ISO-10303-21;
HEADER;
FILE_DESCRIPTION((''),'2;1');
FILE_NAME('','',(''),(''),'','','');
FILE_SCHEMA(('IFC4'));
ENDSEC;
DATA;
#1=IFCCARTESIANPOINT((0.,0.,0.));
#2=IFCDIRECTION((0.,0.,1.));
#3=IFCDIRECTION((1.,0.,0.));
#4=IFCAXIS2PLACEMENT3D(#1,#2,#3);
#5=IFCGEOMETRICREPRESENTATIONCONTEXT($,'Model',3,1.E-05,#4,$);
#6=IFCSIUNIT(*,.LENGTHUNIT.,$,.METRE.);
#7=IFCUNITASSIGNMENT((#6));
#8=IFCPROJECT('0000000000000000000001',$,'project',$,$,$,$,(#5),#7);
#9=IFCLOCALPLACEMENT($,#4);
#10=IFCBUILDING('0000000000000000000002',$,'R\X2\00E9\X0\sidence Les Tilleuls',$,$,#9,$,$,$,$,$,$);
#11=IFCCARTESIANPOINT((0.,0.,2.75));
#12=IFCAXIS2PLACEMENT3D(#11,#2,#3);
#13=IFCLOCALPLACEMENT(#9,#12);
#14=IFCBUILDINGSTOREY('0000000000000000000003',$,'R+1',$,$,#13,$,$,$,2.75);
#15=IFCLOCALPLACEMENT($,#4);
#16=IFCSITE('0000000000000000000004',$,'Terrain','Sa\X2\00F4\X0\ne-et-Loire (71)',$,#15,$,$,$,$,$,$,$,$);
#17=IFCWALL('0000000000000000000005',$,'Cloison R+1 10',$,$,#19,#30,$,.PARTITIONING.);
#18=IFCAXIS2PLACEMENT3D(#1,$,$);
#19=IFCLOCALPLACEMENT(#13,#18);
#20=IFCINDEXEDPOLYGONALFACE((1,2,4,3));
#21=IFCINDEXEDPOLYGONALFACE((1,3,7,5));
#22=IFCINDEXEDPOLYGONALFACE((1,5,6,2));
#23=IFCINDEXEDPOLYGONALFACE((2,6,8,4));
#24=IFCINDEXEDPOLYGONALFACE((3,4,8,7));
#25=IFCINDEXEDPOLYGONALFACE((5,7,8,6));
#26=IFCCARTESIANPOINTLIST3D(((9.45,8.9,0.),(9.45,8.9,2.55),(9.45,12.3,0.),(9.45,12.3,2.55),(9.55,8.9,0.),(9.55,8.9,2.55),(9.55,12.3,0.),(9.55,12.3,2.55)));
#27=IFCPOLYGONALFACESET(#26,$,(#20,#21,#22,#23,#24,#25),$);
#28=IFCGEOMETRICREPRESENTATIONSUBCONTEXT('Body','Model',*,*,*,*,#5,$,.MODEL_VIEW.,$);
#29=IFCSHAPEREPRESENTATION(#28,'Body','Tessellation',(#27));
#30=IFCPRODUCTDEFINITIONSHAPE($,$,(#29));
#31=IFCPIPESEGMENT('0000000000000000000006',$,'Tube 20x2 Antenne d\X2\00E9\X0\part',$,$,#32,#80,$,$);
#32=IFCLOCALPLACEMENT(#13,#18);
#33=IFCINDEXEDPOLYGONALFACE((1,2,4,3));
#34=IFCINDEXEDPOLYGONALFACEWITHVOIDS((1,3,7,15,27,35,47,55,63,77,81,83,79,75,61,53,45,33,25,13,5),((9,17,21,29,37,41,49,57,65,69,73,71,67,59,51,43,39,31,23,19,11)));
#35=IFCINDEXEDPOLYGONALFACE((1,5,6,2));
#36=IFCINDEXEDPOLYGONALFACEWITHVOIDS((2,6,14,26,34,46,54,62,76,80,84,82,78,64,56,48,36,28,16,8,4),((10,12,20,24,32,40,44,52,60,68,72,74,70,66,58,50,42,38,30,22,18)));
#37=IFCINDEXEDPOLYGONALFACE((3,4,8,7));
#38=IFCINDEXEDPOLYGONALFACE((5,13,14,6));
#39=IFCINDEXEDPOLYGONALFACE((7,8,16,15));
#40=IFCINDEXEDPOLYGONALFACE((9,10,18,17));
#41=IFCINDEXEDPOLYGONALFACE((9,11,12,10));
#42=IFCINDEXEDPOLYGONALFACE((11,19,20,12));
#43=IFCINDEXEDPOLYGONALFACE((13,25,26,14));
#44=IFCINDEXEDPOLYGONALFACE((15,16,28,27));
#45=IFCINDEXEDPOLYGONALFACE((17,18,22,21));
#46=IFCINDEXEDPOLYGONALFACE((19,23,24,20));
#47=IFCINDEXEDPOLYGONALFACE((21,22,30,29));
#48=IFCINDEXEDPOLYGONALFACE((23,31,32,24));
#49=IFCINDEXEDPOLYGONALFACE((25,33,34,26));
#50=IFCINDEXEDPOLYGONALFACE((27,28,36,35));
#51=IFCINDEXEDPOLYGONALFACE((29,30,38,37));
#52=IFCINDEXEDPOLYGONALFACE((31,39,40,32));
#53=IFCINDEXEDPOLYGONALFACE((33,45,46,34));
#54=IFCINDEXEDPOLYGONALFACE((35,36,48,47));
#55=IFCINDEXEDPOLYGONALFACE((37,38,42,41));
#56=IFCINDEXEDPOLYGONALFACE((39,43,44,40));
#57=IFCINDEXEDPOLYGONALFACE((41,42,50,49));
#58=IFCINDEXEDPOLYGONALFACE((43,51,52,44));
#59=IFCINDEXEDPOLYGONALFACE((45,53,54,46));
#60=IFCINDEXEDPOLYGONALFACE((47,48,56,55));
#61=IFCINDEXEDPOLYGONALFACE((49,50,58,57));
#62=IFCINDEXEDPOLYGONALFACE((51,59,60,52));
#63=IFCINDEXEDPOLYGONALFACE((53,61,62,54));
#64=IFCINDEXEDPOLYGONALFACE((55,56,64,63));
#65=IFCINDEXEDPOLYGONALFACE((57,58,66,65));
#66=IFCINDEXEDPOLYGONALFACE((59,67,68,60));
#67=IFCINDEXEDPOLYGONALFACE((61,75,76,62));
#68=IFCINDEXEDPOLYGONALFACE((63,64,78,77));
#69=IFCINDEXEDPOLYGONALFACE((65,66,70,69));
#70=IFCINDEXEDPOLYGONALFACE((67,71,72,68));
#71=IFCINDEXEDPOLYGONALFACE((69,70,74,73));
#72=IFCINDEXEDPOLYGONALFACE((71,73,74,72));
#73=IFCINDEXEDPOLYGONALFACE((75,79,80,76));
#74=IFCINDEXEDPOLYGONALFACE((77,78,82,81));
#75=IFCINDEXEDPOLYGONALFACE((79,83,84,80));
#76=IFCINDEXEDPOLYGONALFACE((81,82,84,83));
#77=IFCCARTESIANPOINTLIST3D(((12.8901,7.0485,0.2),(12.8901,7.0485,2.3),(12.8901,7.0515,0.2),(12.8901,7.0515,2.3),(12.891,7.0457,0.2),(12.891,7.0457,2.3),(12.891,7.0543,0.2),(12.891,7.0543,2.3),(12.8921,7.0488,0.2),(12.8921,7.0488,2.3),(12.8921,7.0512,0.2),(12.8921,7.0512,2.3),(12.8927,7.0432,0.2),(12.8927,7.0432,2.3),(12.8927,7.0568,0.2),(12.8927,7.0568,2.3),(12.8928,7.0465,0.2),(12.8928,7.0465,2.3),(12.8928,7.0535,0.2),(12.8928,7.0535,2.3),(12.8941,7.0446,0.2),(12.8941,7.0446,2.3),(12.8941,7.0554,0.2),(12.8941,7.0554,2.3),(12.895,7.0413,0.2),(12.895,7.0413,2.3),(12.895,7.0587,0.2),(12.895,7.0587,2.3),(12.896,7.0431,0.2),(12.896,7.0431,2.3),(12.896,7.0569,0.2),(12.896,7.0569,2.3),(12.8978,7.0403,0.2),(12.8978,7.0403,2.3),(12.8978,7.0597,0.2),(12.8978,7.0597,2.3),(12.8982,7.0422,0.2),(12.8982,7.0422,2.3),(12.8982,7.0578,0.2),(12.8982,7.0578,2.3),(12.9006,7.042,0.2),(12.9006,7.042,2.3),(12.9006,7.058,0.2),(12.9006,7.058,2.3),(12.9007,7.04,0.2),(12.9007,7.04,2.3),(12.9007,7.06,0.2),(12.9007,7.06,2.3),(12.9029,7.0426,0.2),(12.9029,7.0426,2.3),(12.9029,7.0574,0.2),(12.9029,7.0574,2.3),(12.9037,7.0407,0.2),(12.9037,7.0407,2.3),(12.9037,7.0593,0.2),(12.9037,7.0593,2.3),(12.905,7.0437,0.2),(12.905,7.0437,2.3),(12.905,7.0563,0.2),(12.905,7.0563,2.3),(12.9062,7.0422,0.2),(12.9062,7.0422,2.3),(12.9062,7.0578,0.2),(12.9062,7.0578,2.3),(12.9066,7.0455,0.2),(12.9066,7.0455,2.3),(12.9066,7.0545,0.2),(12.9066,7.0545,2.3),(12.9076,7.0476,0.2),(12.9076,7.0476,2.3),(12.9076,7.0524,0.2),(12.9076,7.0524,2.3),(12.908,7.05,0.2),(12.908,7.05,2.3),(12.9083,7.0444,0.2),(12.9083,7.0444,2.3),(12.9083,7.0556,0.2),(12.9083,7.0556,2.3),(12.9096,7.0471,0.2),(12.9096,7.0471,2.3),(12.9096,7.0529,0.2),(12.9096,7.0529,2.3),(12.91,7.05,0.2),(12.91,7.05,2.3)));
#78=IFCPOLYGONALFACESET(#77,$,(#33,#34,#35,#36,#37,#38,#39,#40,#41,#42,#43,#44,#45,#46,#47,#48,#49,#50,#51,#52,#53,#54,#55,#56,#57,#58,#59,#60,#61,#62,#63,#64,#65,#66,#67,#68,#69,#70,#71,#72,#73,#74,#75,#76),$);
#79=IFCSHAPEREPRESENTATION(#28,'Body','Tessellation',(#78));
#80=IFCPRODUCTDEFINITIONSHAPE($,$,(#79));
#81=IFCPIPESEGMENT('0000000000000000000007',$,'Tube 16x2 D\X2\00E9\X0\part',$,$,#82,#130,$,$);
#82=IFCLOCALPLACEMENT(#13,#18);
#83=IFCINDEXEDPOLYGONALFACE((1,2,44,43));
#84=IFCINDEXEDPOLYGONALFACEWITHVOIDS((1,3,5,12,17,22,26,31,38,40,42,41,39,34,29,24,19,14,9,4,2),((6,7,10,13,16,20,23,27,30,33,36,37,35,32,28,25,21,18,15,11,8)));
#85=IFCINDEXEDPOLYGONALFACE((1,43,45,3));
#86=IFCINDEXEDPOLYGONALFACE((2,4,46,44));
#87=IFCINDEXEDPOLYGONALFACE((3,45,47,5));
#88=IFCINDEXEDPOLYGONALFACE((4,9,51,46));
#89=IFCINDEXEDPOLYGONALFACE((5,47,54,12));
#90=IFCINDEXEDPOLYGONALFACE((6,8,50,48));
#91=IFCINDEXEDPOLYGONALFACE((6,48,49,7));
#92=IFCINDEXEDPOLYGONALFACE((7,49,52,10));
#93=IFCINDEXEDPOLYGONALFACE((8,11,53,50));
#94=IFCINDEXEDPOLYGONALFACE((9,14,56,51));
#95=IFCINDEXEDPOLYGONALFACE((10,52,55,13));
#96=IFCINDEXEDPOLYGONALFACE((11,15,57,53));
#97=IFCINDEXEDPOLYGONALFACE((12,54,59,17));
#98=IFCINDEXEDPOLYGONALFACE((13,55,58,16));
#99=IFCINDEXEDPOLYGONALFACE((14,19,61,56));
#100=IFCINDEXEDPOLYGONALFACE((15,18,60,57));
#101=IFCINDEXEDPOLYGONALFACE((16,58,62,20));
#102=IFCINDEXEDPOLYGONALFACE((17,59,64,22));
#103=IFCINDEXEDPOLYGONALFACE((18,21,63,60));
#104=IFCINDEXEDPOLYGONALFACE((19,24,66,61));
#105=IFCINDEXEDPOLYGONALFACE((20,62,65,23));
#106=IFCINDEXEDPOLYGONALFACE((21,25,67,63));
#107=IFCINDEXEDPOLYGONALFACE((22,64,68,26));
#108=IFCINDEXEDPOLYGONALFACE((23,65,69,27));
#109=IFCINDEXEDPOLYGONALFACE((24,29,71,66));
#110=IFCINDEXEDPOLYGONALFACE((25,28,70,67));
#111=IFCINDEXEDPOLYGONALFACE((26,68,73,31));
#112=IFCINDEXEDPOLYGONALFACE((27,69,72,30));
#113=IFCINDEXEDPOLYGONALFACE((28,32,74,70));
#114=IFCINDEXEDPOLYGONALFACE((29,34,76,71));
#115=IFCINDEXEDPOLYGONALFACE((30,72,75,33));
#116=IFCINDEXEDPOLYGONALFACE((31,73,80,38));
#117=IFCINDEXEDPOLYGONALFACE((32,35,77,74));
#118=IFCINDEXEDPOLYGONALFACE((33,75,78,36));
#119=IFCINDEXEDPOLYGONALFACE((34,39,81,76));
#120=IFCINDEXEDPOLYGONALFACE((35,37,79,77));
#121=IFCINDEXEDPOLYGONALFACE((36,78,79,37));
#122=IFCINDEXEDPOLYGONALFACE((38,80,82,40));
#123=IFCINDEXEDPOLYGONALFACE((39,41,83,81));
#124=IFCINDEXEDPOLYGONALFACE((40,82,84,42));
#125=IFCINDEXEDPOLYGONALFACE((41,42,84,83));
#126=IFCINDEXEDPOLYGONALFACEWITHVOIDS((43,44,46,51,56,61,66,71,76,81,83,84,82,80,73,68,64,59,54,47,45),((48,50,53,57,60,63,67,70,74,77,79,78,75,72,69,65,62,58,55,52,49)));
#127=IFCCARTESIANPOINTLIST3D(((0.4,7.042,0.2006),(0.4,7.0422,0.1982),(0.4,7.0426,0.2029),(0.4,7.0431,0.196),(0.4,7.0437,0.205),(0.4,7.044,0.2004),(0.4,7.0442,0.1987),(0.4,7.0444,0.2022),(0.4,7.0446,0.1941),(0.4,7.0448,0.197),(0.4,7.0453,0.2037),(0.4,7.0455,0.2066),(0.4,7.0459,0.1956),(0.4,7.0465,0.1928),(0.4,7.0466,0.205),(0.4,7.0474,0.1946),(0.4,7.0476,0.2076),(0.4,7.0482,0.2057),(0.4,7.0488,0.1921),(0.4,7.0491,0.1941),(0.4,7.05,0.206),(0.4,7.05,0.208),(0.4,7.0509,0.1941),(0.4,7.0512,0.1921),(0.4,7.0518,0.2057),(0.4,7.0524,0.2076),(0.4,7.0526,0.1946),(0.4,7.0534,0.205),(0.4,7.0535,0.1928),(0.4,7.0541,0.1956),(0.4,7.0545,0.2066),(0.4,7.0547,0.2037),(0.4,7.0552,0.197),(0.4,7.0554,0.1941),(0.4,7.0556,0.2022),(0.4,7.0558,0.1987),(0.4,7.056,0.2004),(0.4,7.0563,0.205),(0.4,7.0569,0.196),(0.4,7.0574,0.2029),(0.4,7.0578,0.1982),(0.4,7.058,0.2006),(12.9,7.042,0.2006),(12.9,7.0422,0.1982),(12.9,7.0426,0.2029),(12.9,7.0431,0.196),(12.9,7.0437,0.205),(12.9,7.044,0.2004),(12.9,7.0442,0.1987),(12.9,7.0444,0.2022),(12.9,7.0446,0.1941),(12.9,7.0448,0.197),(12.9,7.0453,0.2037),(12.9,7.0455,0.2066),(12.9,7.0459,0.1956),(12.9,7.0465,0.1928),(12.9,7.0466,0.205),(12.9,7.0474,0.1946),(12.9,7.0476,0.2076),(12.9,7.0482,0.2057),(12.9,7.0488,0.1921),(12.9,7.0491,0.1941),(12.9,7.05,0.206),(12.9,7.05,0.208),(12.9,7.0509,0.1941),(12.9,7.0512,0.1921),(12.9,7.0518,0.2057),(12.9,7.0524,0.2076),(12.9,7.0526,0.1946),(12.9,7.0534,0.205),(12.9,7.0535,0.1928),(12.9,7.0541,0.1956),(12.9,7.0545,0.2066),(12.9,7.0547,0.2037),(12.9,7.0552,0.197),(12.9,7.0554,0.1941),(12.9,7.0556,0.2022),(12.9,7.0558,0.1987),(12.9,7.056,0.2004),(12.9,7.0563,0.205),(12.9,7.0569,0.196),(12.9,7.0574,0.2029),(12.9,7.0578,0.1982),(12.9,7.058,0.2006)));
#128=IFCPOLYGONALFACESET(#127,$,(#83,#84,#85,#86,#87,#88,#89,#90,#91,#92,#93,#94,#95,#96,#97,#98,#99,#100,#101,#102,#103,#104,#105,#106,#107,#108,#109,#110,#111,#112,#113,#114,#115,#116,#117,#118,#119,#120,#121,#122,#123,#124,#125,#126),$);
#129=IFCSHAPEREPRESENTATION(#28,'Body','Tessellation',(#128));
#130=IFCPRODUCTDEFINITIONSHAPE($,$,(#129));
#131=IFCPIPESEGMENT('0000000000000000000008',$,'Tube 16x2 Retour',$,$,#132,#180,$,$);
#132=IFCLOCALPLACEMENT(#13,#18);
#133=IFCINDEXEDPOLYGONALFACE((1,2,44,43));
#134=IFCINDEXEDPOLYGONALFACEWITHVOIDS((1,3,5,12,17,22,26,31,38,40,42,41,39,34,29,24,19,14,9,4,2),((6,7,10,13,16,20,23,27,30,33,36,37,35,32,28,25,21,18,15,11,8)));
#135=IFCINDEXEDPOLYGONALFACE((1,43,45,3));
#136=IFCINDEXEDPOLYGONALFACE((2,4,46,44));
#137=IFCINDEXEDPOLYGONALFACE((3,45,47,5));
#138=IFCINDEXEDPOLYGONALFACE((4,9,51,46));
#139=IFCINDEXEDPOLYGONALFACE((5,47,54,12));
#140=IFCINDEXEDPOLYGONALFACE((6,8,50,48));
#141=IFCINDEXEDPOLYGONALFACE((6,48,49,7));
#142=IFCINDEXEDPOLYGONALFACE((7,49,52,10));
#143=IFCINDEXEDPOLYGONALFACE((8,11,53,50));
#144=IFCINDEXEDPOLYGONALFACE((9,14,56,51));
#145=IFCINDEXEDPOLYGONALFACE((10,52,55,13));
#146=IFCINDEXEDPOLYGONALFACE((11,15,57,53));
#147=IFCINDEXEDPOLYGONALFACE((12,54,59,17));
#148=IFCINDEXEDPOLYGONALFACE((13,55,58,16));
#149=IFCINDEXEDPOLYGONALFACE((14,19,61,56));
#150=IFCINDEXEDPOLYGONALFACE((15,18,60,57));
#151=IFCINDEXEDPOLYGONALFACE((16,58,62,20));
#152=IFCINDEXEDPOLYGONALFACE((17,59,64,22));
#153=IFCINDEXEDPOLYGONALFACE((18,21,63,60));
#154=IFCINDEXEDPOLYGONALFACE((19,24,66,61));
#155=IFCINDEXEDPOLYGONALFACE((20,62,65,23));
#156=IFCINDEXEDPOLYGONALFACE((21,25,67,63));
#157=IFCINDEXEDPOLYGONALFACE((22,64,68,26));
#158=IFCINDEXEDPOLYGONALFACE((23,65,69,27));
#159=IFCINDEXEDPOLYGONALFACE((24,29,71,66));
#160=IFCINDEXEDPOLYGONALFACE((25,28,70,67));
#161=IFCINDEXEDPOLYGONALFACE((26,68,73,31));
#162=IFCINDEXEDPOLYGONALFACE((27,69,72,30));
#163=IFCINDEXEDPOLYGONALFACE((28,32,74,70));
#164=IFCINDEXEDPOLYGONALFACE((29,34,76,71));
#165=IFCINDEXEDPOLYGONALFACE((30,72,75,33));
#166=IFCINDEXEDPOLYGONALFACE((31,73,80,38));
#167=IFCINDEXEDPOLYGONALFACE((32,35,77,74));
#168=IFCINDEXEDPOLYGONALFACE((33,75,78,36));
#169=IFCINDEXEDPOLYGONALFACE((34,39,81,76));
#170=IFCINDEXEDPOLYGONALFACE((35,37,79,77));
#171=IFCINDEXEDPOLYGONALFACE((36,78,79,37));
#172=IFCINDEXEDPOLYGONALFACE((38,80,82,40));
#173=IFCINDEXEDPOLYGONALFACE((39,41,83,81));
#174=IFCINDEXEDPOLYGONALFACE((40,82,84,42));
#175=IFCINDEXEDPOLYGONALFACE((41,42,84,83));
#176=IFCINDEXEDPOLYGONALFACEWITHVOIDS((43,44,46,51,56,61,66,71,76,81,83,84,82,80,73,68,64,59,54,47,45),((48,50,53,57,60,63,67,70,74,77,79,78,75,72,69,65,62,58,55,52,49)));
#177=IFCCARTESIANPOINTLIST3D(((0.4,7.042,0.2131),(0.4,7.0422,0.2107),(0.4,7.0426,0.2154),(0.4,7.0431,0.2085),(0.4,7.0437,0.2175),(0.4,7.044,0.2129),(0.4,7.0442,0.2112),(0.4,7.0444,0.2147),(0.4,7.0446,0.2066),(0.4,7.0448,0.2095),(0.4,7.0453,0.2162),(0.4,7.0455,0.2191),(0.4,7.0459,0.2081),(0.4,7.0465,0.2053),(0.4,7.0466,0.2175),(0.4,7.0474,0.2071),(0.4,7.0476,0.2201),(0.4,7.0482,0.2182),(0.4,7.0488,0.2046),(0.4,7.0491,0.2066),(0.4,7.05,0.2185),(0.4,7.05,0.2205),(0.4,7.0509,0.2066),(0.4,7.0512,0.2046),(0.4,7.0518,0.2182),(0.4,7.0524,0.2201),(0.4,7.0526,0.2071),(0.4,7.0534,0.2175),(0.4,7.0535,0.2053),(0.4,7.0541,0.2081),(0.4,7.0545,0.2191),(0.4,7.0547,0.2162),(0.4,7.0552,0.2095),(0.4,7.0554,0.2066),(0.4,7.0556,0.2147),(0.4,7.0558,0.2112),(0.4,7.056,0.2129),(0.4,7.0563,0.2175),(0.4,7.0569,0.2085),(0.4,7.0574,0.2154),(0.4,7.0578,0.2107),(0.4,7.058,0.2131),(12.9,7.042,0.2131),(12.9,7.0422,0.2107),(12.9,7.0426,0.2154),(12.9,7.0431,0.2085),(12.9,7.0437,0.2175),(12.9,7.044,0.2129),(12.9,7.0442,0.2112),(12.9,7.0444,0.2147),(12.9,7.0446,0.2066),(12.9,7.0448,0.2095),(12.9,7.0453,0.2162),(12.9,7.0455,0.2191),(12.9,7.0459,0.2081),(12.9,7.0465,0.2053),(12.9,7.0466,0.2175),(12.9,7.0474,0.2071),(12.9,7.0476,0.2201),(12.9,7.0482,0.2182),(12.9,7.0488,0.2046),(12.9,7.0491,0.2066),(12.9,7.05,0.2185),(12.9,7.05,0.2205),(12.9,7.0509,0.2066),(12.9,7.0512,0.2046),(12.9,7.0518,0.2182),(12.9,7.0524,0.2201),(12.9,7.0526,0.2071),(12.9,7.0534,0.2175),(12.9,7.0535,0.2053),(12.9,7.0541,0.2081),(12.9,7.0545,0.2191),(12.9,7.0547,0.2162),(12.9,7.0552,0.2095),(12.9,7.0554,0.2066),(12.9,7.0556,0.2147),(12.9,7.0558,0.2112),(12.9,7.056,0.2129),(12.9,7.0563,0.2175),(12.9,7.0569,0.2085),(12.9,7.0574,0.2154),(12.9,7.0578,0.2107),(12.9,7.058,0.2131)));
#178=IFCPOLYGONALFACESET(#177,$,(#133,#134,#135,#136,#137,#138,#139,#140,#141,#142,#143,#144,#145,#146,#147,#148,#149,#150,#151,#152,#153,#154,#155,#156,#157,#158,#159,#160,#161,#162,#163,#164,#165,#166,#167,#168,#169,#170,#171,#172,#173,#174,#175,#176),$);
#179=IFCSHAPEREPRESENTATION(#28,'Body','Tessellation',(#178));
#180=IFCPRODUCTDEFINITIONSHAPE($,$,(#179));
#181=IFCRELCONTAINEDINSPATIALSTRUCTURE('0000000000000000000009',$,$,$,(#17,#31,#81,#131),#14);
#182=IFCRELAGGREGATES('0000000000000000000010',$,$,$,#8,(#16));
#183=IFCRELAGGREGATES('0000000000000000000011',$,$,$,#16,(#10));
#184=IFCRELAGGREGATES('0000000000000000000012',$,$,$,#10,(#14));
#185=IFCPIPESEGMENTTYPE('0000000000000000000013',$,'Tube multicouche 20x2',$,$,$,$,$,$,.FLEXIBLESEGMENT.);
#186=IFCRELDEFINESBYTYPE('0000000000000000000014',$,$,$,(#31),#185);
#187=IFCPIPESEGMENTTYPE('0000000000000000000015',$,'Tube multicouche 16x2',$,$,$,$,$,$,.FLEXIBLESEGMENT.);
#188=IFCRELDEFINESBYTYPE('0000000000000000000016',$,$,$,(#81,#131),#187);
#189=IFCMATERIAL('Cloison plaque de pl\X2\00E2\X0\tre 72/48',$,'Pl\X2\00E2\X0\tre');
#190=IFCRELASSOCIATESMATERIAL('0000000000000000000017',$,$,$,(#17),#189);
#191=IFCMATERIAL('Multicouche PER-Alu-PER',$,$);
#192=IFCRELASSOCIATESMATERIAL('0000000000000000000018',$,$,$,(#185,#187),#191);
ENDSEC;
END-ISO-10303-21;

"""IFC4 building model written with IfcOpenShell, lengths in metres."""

from ifc_helpers import new_model, si_unit, frame, frame_2d, origin_with_axes, place, context, subcontext, project, spatial, rectangle, hollow_circle, extrude, material, type_object, element, save


model = new_model("IFC4")

# Units and contexts
model_context = context("Model", 3, precision=1e-05, world=origin_with_axes())
body_context = subcontext(model_context, "Body", "Model", "MODEL_VIEW")
ifc_project = project(units=[si_unit("LENGTHUNIT", "METRE")], contexts=[model_context])

# Site, building, storey
site_placement = place(None, origin_with_axes())
site = spatial("IfcSite", under=ifc_project, at=site_placement, Name="Terrain", Description="Saône-et-Loire (71)")
building_placement = place(None, origin_with_axes())
building = spatial("IfcBuilding", under=site, at=building_placement, Name="Résidence Les Tilleuls")
storey_placement = place(building_placement, frame((0.0, 0.0, 2.75), z_axis=(0.0, 0.0, 1.0), x_axis=(1.0, 0.0, 0.0)))
storey = spatial("IfcBuildingStorey", under=building, at=storey_placement, Name="R+1", Elevation=2.75)

# Wall
ifc_material_1 = material(Name="Cloison plaque de plâtre 72/48", Category="Plâtre")
wall_placement = place(storey_placement, frame((9.45, 8.9, 0.0), z_axis=(0.0, 0.0, 1.0), x_axis=(1.0, 0.0, 0.0)))
element("IfcWall", 1, at=wall_placement, inside=storey, material=ifc_material_1, Name="Cloison R+1 10", PredefinedType="PARTITIONING", context=body_context, shape_type="SweptSolid", body=[
    extrude(rectangle(XDim=0.1, YDim=3.4, at=frame_2d((0.05, 1.7))), origin_with_axes(), (0.0, 0.0, 1.0), 2.55),
])

# Pipe segments
ifc_material_2 = material(Name="Multicouche PER-Alu-PER")
pipe_segment_type_1 = type_object("IfcPipeSegmentType", Name="Tube multicouche 20x2", PredefinedType="FLEXIBLESEGMENT", material=ifc_material_2)
pipe_segment_1_placement = place(storey_placement, frame((12.9, 7.05, 2.3), z_axis=(0.0, 0.0, -1.0), x_axis=(1.0, 0.0, 0.0)))
element("IfcPipeSegment", 2, at=pipe_segment_1_placement, inside=storey, type_object=pipe_segment_type_1, Name="Tube 20x2 Antenne départ", context=body_context, shape_type="SweptSolid", body=[
    extrude(hollow_circle(Radius=0.01, WallThickness=0.002), origin_with_axes(), (0.0, 0.0, 1.0), 2.1),
])
pipe_segment_type_2 = type_object("IfcPipeSegmentType", Name="Tube multicouche 16x2", PredefinedType="FLEXIBLESEGMENT", material=ifc_material_2)
for number, where, z_axis, x_axis, name in (
    (3, (12.9, 7.05, 0.2), (-1.0, 0.0, 0.0), (0.0, 0.0, 1.0), "Tube 16x2 Départ"),
    (4, (12.9, 7.05, 0.2125), (-1.0, 0.0, 0.0), (0.0, 0.0, 1.0), "Tube 16x2 Retour"),
):
    element("IfcPipeSegment", number, at=place(storey_placement, frame(where, z_axis=z_axis, x_axis=x_axis)), inside=storey, type_object=pipe_segment_type_2, Name=name, context=body_context, shape_type="SweptSolid", body=[
        extrude(hollow_circle(Radius=0.008, WallThickness=0.002), origin_with_axes(), (0.0, 0.0, 1.0), 12.5),
    ])

save(model, "model.ifc")
